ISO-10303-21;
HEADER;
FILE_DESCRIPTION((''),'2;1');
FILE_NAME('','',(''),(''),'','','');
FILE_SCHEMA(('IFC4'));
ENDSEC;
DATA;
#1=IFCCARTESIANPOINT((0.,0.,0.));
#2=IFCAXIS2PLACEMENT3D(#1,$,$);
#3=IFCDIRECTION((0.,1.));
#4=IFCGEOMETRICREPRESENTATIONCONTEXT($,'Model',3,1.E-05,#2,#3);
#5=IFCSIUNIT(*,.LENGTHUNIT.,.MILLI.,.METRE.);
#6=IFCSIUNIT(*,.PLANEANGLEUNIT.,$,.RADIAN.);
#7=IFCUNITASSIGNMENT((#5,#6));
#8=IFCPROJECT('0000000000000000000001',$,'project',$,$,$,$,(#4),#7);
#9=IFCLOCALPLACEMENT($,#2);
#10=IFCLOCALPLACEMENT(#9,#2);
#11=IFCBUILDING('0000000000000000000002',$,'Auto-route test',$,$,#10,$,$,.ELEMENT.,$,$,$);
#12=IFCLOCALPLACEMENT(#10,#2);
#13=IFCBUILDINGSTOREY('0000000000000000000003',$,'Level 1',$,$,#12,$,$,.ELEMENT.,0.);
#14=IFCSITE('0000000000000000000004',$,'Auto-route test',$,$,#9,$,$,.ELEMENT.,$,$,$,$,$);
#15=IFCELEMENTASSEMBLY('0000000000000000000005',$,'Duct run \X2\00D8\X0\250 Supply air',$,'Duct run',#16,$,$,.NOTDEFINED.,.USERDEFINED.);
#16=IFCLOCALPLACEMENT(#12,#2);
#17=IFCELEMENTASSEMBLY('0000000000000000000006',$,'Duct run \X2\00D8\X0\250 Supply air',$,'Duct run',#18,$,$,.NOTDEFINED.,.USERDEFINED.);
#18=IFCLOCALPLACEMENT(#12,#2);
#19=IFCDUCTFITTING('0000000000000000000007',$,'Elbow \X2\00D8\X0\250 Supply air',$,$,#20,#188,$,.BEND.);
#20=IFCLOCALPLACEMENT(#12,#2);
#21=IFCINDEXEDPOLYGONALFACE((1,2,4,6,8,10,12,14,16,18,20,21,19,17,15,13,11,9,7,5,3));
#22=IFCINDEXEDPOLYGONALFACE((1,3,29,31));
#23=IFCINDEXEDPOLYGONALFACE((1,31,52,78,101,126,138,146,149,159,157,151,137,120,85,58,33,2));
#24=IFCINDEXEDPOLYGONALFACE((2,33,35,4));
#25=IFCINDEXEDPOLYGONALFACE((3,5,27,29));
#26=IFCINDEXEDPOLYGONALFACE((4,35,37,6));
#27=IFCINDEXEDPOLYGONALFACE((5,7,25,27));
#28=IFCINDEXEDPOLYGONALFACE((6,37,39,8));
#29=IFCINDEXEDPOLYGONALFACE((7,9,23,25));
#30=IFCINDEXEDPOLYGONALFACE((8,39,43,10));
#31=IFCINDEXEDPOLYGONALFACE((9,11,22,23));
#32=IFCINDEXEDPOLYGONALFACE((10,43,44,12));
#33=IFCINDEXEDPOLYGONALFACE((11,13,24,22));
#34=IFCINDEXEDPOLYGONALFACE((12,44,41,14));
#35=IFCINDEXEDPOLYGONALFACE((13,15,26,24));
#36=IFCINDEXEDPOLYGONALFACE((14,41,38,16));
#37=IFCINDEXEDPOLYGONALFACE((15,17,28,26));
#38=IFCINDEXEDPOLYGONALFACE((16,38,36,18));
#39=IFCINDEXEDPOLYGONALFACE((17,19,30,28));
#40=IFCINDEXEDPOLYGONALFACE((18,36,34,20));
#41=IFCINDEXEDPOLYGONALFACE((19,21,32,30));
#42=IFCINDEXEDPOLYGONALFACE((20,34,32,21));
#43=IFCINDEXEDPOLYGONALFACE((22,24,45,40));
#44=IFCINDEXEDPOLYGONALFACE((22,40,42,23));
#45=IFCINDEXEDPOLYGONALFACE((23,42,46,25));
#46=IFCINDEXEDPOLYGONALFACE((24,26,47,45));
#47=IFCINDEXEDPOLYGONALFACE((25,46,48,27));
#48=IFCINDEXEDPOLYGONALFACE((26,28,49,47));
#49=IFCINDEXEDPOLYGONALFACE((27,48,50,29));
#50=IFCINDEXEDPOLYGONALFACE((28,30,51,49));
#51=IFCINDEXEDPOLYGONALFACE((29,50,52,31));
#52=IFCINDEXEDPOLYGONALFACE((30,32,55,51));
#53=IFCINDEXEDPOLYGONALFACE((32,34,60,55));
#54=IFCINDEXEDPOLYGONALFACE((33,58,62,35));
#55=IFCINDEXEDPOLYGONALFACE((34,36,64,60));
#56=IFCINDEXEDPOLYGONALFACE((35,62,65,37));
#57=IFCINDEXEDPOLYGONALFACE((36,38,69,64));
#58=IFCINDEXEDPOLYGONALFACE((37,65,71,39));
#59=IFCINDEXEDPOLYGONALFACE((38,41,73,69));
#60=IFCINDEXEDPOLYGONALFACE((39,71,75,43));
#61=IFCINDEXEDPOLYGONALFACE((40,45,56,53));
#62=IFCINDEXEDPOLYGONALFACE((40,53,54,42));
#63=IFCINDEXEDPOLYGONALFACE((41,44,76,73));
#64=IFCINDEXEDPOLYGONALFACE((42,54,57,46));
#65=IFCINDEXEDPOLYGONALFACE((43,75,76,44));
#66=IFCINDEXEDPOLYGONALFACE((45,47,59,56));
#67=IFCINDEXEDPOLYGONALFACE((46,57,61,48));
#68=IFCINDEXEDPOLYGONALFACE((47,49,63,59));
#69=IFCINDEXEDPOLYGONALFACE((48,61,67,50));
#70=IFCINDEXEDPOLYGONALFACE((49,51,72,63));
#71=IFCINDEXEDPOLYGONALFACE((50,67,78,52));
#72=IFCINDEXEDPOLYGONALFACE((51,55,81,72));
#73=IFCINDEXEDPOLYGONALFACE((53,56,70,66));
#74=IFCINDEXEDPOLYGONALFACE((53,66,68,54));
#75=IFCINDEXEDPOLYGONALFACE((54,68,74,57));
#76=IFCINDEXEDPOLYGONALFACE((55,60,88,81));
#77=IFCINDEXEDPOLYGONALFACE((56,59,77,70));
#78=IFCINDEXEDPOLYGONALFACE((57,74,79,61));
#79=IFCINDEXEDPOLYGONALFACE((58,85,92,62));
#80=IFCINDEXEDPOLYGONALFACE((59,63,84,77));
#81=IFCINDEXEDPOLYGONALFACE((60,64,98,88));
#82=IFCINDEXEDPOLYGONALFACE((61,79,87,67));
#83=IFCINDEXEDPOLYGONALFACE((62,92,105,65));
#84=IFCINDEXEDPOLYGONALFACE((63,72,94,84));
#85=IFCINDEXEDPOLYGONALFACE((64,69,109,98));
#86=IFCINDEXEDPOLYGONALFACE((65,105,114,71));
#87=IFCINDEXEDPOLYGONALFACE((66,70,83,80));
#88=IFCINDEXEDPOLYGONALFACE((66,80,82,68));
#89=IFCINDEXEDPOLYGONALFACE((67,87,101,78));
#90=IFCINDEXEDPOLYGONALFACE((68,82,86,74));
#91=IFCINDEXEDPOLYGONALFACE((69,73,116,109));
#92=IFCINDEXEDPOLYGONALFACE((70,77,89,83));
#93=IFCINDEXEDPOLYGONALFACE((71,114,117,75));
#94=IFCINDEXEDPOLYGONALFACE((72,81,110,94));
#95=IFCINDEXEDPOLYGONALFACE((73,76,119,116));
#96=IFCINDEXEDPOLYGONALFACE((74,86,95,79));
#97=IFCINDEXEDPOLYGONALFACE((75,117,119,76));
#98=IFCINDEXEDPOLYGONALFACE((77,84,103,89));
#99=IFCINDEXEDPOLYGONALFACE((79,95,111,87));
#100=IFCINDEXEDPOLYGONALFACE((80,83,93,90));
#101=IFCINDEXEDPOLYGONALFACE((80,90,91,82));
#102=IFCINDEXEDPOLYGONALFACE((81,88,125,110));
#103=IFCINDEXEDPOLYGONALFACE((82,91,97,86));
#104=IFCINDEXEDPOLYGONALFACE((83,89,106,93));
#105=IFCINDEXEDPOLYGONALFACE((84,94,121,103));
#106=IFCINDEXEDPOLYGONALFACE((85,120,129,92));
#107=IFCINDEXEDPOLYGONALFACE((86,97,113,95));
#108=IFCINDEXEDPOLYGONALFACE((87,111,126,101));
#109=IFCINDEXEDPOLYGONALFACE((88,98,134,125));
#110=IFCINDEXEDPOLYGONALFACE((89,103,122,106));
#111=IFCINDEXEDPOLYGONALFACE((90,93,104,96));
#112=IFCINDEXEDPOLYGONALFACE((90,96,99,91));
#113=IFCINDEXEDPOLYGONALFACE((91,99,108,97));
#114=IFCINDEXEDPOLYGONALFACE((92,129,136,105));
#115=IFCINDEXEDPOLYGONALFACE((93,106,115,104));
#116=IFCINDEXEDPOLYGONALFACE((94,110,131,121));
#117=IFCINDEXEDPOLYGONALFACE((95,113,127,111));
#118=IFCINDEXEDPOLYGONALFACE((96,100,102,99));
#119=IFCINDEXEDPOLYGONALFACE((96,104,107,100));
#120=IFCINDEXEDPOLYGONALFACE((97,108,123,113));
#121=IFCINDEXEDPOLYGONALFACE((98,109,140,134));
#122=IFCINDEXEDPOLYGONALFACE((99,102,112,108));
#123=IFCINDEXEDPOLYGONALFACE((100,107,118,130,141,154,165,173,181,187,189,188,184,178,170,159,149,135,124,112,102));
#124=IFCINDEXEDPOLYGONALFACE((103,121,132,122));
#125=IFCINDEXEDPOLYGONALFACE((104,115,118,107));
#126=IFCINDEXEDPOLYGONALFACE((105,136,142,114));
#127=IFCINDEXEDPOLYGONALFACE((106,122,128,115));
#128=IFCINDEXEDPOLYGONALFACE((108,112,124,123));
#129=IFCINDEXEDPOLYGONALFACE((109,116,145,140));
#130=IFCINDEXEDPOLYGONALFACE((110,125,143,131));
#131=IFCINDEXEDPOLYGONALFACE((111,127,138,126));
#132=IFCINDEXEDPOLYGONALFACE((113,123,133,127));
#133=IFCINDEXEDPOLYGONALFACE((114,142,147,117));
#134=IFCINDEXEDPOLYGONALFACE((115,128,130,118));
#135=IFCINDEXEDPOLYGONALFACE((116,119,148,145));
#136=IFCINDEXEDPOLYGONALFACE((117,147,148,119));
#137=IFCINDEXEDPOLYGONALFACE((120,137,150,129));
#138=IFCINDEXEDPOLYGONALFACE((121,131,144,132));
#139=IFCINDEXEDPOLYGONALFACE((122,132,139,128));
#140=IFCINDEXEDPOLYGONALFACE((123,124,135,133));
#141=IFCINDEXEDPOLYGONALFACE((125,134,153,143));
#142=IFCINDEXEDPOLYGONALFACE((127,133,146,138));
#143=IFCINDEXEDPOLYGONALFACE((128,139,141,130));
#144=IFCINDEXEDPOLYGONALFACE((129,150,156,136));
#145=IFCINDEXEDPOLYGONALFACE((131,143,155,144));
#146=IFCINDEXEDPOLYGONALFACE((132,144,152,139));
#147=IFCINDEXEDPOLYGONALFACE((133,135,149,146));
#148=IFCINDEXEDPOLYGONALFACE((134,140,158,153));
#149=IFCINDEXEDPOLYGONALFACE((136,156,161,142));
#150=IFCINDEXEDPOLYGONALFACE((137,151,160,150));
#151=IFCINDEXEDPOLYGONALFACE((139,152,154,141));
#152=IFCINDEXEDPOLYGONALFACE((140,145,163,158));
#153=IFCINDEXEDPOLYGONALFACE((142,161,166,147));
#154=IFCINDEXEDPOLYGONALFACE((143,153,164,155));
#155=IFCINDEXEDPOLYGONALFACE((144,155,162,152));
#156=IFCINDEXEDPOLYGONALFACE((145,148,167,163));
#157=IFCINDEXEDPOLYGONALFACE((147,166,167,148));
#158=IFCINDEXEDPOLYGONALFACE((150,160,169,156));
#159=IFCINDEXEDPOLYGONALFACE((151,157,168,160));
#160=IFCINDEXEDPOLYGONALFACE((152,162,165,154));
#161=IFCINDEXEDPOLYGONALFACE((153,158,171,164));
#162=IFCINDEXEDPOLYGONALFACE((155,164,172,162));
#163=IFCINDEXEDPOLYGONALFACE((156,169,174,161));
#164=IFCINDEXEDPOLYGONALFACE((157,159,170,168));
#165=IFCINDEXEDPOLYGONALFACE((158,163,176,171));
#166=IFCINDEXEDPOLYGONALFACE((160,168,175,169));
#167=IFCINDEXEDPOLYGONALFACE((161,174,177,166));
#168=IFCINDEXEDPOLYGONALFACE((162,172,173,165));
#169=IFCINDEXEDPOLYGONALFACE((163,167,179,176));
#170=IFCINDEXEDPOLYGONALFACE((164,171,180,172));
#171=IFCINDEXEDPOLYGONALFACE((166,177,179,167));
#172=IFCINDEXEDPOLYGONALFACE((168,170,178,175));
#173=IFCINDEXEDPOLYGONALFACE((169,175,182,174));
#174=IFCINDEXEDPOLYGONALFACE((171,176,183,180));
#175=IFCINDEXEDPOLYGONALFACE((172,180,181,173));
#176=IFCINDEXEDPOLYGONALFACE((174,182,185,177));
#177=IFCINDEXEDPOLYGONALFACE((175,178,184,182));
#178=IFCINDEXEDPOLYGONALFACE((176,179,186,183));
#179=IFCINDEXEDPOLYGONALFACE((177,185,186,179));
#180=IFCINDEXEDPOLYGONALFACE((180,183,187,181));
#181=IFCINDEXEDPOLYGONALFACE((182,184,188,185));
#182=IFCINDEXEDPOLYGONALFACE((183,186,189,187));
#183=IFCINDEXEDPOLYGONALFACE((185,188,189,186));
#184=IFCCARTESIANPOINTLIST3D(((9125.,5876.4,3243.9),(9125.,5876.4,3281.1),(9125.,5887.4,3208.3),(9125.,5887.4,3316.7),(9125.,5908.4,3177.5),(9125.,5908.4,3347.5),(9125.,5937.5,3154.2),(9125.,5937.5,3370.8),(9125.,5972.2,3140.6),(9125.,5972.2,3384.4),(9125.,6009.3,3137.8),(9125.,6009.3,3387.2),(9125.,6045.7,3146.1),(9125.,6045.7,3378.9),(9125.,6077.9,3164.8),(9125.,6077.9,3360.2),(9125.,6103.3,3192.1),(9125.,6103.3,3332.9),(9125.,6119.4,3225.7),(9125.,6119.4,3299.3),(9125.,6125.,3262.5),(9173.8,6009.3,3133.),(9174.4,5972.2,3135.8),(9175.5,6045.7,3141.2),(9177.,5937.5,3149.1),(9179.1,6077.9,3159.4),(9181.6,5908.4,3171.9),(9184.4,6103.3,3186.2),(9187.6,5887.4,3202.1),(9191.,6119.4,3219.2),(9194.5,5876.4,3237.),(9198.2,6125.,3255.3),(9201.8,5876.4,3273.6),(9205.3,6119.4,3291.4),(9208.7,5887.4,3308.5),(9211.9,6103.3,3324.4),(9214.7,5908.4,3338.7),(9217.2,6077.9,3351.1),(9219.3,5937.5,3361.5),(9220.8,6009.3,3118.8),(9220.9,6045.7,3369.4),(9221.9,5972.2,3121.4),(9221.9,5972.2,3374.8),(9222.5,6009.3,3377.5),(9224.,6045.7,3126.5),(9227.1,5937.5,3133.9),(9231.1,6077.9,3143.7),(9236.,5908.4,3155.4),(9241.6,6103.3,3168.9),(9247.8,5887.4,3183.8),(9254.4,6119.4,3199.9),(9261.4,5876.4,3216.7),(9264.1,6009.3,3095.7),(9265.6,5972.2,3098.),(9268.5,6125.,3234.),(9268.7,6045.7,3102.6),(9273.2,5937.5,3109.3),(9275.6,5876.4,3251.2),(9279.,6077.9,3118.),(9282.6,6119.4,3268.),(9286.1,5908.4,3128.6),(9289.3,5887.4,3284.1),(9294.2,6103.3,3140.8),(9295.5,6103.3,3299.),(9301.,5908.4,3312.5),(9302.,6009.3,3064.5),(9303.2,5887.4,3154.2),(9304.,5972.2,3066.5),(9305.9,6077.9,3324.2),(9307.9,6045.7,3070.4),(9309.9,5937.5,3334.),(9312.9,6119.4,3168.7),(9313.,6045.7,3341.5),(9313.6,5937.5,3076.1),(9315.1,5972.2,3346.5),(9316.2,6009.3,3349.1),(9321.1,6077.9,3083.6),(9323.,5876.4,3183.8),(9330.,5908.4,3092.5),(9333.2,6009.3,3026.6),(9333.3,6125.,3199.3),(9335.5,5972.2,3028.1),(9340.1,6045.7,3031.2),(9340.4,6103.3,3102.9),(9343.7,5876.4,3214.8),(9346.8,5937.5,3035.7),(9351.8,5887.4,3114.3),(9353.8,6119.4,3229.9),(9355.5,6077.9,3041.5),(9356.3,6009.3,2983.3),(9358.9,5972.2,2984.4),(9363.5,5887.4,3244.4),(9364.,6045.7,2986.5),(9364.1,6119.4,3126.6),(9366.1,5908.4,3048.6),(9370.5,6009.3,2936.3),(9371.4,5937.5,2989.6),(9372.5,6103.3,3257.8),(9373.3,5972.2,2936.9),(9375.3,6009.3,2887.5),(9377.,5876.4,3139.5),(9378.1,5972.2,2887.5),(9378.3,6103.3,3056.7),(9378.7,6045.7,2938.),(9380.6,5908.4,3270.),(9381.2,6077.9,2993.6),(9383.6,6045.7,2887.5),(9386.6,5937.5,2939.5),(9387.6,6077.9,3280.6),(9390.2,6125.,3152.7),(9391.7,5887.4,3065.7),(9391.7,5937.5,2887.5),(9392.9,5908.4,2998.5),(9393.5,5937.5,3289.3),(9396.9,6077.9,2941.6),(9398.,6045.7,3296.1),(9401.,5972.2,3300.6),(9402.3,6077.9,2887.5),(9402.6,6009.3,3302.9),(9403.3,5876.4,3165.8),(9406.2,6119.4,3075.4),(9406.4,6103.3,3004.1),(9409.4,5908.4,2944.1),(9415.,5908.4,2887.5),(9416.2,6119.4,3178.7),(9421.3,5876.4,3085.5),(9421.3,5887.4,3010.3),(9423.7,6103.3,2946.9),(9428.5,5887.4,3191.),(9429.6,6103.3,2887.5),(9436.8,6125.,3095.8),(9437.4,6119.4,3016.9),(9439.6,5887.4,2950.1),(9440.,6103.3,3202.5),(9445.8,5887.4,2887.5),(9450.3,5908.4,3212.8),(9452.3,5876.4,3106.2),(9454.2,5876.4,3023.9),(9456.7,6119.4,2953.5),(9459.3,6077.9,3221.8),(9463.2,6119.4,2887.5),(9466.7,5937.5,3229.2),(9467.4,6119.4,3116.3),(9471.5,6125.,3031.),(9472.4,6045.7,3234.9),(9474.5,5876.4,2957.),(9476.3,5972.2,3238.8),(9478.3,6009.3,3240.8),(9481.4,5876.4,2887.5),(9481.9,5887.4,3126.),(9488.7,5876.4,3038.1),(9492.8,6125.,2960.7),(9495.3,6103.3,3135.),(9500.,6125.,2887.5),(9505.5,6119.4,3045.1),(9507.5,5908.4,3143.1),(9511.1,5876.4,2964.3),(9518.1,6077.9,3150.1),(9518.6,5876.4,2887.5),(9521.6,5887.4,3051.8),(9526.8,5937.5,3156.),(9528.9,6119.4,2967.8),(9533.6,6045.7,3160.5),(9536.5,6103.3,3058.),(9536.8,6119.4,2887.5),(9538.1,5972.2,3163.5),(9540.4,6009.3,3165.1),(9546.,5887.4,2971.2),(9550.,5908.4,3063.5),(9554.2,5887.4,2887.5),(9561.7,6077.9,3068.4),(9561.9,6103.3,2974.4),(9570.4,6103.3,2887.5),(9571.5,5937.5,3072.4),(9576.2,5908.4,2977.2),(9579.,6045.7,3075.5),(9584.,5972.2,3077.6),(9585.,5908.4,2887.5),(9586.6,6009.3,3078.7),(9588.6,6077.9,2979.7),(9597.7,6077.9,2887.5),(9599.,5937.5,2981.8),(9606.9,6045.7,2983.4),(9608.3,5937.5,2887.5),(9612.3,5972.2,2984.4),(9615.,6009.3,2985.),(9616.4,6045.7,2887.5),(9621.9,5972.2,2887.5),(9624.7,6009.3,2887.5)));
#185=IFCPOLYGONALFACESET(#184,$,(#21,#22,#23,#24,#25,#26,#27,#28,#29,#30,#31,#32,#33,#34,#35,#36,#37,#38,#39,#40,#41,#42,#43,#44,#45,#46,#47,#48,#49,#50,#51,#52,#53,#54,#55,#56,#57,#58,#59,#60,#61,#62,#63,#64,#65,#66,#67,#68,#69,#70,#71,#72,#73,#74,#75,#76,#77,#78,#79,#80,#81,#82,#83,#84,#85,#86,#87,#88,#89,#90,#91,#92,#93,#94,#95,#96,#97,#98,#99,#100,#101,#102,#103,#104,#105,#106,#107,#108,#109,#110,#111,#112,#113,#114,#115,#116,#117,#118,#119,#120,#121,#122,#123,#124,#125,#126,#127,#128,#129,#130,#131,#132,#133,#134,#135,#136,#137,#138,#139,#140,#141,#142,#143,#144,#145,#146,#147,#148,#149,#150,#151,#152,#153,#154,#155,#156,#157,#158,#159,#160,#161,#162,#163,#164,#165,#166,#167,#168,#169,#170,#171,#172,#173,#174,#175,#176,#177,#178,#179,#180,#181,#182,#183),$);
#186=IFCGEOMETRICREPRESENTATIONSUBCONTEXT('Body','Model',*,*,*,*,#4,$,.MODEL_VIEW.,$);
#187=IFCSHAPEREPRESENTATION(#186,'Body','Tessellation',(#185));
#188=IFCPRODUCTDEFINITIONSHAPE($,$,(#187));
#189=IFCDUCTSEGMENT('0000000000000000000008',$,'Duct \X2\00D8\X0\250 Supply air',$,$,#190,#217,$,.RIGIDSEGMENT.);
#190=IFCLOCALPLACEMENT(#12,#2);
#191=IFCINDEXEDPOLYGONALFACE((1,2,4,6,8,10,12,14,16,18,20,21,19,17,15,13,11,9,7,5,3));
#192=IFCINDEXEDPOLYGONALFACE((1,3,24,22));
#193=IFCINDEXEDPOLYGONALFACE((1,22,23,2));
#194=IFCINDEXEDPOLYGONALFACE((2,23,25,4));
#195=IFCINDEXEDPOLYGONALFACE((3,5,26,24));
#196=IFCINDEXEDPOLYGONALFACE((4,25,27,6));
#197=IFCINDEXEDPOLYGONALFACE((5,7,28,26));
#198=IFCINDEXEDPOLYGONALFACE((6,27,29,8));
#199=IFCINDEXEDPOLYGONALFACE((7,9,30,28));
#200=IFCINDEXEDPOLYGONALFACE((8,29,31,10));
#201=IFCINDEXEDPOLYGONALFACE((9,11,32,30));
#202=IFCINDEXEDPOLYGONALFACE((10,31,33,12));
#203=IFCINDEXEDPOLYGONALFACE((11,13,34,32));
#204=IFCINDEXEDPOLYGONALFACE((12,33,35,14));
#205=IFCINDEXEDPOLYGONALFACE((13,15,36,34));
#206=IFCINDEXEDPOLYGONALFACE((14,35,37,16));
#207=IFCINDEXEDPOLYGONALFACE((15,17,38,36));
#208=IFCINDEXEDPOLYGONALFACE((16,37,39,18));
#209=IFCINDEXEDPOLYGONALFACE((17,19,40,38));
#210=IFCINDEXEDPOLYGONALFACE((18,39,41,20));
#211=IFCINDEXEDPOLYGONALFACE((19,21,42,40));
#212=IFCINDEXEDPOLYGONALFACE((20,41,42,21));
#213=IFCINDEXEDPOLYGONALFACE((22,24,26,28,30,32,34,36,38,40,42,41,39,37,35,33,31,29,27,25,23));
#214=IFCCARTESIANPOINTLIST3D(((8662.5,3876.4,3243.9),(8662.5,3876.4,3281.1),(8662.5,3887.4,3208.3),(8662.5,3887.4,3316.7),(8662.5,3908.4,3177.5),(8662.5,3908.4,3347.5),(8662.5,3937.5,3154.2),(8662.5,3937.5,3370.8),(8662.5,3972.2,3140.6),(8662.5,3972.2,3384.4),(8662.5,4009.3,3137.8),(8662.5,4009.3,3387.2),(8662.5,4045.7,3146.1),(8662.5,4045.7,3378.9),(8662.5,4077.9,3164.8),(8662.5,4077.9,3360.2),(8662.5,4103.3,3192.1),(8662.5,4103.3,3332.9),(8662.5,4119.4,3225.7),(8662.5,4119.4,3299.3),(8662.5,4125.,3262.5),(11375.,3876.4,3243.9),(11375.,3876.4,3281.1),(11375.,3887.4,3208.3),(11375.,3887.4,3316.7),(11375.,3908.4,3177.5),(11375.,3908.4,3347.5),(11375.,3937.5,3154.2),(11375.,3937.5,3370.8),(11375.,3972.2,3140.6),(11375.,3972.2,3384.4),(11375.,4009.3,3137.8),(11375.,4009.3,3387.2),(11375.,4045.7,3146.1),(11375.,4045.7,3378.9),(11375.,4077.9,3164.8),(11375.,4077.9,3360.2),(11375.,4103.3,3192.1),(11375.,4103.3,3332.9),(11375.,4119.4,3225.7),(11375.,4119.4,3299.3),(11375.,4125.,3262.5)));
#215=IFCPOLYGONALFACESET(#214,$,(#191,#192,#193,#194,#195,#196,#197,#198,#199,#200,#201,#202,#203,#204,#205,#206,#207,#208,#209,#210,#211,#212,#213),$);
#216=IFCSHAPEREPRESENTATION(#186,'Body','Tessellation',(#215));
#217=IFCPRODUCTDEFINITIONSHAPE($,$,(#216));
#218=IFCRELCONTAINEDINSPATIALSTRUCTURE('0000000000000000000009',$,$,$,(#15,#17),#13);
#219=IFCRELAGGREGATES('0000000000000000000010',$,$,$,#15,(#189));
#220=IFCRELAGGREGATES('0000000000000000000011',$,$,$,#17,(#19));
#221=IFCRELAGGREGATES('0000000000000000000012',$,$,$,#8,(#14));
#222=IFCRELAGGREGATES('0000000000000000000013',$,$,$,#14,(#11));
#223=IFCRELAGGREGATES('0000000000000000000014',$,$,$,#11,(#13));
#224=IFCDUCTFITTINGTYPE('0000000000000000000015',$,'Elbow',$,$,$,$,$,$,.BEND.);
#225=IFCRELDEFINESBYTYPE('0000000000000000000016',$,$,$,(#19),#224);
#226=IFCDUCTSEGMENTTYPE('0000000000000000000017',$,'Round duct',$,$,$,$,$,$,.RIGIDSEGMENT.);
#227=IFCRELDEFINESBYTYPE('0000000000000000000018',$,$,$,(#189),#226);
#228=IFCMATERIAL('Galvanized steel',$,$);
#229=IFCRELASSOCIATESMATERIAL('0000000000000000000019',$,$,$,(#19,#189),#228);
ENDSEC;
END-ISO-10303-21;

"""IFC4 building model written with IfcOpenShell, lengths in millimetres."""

from ifc_helpers import new_model, entity, si_unit, direction, frame, origin, origin_with_axes, origin_2d, place, context, subcontext, project, spatial, circle, extrude, material, type_object, element, aggregate, save


model = new_model("IFC4")

# Units and contexts
model_context = context("Model", 3, precision=1e-05, world=origin(), true_north=direction((0.0, 1.0)))
body_context = subcontext(model_context, "Body", "Model", "MODEL_VIEW")
ifc_project = project(units=[si_unit("LENGTHUNIT", "METRE", prefix="MILLI"), si_unit("PLANEANGLEUNIT", "RADIAN")], contexts=[model_context])

# Site, building, storey
site_placement = place(None, origin())
site = spatial("IfcSite", under=ifc_project, at=site_placement, Name="Auto-route test", CompositionType="ELEMENT")
building_placement = place(site_placement, origin())
building = spatial("IfcBuilding", under=site, at=building_placement, Name="Auto-route test", CompositionType="ELEMENT")
storey_placement = place(building_placement, origin())
storey = spatial("IfcBuildingStorey", under=building, at=storey_placement, Name="Level 1", CompositionType="ELEMENT", Elevation=0.0)

# Shared definitions
ifc_material_1 = material(Name="Galvanized steel")

# Element assembly
assembly_1_placement = place(storey_placement, origin_with_axes())
assembly_1 = element("IfcElementAssembly", 1, at=assembly_1_placement, inside=storey, Name="Duct run Ø250 Supply air", ObjectType="Duct run", AssemblyPlace="NOTDEFINED", PredefinedType="USERDEFINED")
duct_fitting_type_1 = type_object("IfcDuctFittingType", Name="Elbow", PredefinedType="BEND")

# Element assembly, duct fitting
assembly_2_placement = place(storey_placement, origin_with_axes())
assembly_2 = element("IfcElementAssembly", 2, at=assembly_2_placement, inside=storey, Name="Duct run Ø250 Supply air", ObjectType="Duct run", AssemblyPlace="NOTDEFINED", PredefinedType="USERDEFINED")
duct_fitting_1_placement = place(storey_placement, origin_with_axes())
duct_fitting_1 = element("IfcDuctFitting", 3, at=duct_fitting_1_placement, type_object=duct_fitting_type_1, material=ifc_material_1, Name="Elbow Ø250 Supply air", PredefinedType="BEND", context=body_context, shape_type="SweptSolid", body=[
    entity("IfcRevolvedAreaSolid", entity("IfcCircleProfileDef", "AREA", None, entity("IfcAxis2Placement2D", entity("IfcCartesianPoint", [0.0, 0.0])), 125.0), entity("IfcAxis2Placement3D", entity("IfcCartesianPoint", [9125.0, 6000.0, 3262.5]), entity("IfcDirection", [1.0, 0.0, 0.0]), entity("IfcDirection", [0.0, 1.0, 0.0])), entity("IfcAxis1Placement", entity("IfcCartesianPoint", [0.0, -375.0, 0.0]), entity("IfcDirection", [1.0, 0.0, 0.0])), 1.570796),
])

# Duct segment
duct_segment_type_1 = type_object("IfcDuctSegmentType", Name="Round duct", PredefinedType="RIGIDSEGMENT")
duct_segment_1_placement = place(storey_placement, origin_with_axes())
duct_segment_1 = element("IfcDuctSegment", 4, at=duct_segment_1_placement, type_object=duct_segment_type_1, material=ifc_material_1, Name="Duct Ø250 Supply air", PredefinedType="RIGIDSEGMENT", context=body_context, shape_type="SweptSolid", body=[
    extrude(circle(Radius=125.0, at=origin_2d()), frame((8662.5, 4000.0, 3262.5), z_axis=(1.0, 0.0, 0.0), x_axis=(0.0, 1.0, 0.0)), (0.0, 0.0, 1.0), 2712.5),
])
aggregate(assembly_1, [duct_segment_1])
aggregate(assembly_2, [duct_fitting_1])

save(model, "model.ifc")
